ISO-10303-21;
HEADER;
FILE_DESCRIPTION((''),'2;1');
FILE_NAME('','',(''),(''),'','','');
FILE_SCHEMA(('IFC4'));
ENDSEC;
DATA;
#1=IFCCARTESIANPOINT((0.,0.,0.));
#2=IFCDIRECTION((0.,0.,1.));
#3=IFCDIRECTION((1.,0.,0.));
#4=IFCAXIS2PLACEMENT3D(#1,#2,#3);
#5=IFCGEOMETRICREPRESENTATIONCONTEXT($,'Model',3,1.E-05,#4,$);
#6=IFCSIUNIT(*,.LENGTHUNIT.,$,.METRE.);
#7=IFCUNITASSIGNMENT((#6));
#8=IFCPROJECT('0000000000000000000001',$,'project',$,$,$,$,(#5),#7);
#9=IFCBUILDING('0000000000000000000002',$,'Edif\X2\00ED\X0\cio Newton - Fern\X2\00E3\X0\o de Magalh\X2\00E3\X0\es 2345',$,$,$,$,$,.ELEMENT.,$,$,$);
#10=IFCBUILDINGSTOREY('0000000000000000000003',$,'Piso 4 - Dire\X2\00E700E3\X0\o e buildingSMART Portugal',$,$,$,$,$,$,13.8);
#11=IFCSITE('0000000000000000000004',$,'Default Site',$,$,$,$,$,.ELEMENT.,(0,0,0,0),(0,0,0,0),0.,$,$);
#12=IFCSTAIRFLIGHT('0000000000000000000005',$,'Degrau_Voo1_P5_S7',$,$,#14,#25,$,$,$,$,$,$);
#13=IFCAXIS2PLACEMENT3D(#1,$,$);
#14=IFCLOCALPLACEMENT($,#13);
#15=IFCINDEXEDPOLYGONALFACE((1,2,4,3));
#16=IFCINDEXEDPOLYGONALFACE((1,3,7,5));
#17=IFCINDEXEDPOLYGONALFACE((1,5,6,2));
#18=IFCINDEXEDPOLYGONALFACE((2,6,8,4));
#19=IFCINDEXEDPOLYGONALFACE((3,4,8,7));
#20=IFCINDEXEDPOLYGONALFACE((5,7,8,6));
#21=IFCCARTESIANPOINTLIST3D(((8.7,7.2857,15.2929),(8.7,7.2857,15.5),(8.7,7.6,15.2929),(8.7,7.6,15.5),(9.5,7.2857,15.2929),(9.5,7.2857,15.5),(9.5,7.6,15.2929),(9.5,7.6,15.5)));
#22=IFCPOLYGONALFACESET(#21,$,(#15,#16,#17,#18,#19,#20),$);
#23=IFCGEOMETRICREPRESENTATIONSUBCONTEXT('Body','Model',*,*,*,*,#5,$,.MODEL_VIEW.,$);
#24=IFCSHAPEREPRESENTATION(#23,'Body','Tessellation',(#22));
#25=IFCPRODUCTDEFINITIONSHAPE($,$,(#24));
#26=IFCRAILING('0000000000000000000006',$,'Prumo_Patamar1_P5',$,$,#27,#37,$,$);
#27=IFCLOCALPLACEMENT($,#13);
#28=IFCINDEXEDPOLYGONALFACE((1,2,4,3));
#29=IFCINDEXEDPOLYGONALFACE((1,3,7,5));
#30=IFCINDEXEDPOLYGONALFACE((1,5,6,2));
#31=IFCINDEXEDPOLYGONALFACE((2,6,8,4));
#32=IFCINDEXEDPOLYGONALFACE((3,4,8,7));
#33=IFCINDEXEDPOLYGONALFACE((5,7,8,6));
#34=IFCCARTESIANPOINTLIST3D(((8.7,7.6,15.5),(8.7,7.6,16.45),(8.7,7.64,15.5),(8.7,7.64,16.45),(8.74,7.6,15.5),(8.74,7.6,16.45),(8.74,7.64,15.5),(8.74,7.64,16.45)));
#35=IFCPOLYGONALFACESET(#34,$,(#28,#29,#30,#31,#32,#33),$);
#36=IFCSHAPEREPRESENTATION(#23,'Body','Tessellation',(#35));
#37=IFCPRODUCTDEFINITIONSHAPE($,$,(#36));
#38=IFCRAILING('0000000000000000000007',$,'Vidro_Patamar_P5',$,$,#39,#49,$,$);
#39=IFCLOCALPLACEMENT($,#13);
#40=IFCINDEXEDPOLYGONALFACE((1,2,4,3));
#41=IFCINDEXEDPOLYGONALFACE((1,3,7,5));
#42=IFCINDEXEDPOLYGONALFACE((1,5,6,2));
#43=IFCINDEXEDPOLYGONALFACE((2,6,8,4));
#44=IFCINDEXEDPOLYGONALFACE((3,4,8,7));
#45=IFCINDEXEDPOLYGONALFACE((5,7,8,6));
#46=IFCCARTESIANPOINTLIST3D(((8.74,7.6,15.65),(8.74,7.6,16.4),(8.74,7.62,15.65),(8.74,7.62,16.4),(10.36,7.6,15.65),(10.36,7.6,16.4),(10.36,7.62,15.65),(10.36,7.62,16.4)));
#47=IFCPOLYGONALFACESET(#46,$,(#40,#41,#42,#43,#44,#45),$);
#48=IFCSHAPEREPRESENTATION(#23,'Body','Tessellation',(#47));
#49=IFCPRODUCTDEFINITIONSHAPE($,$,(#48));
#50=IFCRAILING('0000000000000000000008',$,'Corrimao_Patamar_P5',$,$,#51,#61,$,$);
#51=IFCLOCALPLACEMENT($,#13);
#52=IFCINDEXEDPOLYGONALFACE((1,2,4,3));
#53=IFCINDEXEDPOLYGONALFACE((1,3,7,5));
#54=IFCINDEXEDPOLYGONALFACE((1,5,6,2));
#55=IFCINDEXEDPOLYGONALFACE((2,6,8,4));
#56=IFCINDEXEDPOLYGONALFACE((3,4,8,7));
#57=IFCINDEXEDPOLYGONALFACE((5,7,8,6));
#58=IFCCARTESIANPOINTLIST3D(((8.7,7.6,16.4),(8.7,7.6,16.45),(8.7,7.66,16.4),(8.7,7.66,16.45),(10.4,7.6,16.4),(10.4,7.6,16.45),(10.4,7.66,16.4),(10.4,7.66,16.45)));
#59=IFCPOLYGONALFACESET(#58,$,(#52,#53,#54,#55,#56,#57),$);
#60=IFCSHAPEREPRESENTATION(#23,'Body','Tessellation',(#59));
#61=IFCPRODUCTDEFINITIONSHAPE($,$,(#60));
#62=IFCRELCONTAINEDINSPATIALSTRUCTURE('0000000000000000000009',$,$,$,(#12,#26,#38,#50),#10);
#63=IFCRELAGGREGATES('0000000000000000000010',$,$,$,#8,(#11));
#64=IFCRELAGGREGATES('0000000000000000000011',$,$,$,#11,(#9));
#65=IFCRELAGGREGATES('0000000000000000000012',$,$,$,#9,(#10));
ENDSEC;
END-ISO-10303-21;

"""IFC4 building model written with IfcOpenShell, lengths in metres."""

from ifc_helpers import new_model, si_unit, frame, frame_2d, origin_with_axes, place, context, subcontext, project, spatial, rectangle, extrude, element, save


model = new_model("IFC4")

# Units and contexts
model_context = context("Model", 3, precision=1e-05, world=origin_with_axes())
body_context = subcontext(model_context, "Body", "Model", "MODEL_VIEW")
ifc_project = project(units=[si_unit("LENGTHUNIT", "METRE")], contexts=[model_context])

# Site, building, storey
site = spatial("IfcSite", under=ifc_project, Name="Default Site", CompositionType="ELEMENT", RefLatitude=(0, 0, 0, 0), RefLongitude=(0, 0, 0, 0), RefElevation=0.0)
building = spatial("IfcBuilding", under=site, Name="Edifício Newton - Fernão de Magalhães 2345", CompositionType="ELEMENT")
storey = spatial("IfcBuildingStorey", under=building, Name="Piso 4 - Direção e buildingSMART Portugal", Elevation=13.8)

# Stair flight
for number, where, z_axis, x_axis, name in (
    (1, (8.7, 7.2857, 15.2929), (0.0, 0.0, 1.0), (1.0, 0.0, 0.0), "Degrau_Voo1_P5_S7"),
):
    element("IfcStairFlight", number, at=place(None, frame(where, z_axis=z_axis, x_axis=x_axis)), inside=storey, Name=name, context=body_context, shape_type="SweptSolid", body=[
        extrude(rectangle(XDim=0.8, YDim=0.3143, at=frame_2d((0.4, 0.1571))), origin_with_axes(), (0.0, 0.0, 1.0), 0.2071),
    ])

# Railings
railing_1_placement = place(None, frame((8.7, 7.6, 15.5), z_axis=(0.0, 0.0, 1.0), x_axis=(1.0, 0.0, 0.0)))
element("IfcRailing", 2, at=railing_1_placement, inside=storey, Name="Prumo_Patamar1_P5", context=body_context, shape_type="SweptSolid", body=[
    extrude(rectangle(XDim=0.04, YDim=0.04, at=frame_2d((0.02, 0.02))), origin_with_axes(), (0.0, 0.0, 1.0), 0.95),
])
railing_2_placement = place(None, frame((8.74, 7.6, 15.65), z_axis=(0.0, 0.0, 1.0), x_axis=(1.0, 0.0, 0.0)))
element("IfcRailing", 3, at=railing_2_placement, inside=storey, Name="Vidro_Patamar_P5", context=body_context, shape_type="SweptSolid", body=[
    extrude(rectangle(XDim=1.62, YDim=0.02, at=frame_2d((0.81, 0.01))), origin_with_axes(), (0.0, 0.0, 1.0), 0.75),
])
railing_3_placement = place(None, frame((8.7, 7.6, 16.4), z_axis=(0.0, 0.0, 1.0), x_axis=(1.0, 0.0, 0.0)))
element("IfcRailing", 4, at=railing_3_placement, inside=storey, Name="Corrimao_Patamar_P5", context=body_context, shape_type="SweptSolid", body=[
    extrude(rectangle(XDim=1.7, YDim=0.06, at=frame_2d((0.85, 0.03))), origin_with_axes(), (0.0, 0.0, 1.0), 0.05),
])

save(model, "model.ifc")
